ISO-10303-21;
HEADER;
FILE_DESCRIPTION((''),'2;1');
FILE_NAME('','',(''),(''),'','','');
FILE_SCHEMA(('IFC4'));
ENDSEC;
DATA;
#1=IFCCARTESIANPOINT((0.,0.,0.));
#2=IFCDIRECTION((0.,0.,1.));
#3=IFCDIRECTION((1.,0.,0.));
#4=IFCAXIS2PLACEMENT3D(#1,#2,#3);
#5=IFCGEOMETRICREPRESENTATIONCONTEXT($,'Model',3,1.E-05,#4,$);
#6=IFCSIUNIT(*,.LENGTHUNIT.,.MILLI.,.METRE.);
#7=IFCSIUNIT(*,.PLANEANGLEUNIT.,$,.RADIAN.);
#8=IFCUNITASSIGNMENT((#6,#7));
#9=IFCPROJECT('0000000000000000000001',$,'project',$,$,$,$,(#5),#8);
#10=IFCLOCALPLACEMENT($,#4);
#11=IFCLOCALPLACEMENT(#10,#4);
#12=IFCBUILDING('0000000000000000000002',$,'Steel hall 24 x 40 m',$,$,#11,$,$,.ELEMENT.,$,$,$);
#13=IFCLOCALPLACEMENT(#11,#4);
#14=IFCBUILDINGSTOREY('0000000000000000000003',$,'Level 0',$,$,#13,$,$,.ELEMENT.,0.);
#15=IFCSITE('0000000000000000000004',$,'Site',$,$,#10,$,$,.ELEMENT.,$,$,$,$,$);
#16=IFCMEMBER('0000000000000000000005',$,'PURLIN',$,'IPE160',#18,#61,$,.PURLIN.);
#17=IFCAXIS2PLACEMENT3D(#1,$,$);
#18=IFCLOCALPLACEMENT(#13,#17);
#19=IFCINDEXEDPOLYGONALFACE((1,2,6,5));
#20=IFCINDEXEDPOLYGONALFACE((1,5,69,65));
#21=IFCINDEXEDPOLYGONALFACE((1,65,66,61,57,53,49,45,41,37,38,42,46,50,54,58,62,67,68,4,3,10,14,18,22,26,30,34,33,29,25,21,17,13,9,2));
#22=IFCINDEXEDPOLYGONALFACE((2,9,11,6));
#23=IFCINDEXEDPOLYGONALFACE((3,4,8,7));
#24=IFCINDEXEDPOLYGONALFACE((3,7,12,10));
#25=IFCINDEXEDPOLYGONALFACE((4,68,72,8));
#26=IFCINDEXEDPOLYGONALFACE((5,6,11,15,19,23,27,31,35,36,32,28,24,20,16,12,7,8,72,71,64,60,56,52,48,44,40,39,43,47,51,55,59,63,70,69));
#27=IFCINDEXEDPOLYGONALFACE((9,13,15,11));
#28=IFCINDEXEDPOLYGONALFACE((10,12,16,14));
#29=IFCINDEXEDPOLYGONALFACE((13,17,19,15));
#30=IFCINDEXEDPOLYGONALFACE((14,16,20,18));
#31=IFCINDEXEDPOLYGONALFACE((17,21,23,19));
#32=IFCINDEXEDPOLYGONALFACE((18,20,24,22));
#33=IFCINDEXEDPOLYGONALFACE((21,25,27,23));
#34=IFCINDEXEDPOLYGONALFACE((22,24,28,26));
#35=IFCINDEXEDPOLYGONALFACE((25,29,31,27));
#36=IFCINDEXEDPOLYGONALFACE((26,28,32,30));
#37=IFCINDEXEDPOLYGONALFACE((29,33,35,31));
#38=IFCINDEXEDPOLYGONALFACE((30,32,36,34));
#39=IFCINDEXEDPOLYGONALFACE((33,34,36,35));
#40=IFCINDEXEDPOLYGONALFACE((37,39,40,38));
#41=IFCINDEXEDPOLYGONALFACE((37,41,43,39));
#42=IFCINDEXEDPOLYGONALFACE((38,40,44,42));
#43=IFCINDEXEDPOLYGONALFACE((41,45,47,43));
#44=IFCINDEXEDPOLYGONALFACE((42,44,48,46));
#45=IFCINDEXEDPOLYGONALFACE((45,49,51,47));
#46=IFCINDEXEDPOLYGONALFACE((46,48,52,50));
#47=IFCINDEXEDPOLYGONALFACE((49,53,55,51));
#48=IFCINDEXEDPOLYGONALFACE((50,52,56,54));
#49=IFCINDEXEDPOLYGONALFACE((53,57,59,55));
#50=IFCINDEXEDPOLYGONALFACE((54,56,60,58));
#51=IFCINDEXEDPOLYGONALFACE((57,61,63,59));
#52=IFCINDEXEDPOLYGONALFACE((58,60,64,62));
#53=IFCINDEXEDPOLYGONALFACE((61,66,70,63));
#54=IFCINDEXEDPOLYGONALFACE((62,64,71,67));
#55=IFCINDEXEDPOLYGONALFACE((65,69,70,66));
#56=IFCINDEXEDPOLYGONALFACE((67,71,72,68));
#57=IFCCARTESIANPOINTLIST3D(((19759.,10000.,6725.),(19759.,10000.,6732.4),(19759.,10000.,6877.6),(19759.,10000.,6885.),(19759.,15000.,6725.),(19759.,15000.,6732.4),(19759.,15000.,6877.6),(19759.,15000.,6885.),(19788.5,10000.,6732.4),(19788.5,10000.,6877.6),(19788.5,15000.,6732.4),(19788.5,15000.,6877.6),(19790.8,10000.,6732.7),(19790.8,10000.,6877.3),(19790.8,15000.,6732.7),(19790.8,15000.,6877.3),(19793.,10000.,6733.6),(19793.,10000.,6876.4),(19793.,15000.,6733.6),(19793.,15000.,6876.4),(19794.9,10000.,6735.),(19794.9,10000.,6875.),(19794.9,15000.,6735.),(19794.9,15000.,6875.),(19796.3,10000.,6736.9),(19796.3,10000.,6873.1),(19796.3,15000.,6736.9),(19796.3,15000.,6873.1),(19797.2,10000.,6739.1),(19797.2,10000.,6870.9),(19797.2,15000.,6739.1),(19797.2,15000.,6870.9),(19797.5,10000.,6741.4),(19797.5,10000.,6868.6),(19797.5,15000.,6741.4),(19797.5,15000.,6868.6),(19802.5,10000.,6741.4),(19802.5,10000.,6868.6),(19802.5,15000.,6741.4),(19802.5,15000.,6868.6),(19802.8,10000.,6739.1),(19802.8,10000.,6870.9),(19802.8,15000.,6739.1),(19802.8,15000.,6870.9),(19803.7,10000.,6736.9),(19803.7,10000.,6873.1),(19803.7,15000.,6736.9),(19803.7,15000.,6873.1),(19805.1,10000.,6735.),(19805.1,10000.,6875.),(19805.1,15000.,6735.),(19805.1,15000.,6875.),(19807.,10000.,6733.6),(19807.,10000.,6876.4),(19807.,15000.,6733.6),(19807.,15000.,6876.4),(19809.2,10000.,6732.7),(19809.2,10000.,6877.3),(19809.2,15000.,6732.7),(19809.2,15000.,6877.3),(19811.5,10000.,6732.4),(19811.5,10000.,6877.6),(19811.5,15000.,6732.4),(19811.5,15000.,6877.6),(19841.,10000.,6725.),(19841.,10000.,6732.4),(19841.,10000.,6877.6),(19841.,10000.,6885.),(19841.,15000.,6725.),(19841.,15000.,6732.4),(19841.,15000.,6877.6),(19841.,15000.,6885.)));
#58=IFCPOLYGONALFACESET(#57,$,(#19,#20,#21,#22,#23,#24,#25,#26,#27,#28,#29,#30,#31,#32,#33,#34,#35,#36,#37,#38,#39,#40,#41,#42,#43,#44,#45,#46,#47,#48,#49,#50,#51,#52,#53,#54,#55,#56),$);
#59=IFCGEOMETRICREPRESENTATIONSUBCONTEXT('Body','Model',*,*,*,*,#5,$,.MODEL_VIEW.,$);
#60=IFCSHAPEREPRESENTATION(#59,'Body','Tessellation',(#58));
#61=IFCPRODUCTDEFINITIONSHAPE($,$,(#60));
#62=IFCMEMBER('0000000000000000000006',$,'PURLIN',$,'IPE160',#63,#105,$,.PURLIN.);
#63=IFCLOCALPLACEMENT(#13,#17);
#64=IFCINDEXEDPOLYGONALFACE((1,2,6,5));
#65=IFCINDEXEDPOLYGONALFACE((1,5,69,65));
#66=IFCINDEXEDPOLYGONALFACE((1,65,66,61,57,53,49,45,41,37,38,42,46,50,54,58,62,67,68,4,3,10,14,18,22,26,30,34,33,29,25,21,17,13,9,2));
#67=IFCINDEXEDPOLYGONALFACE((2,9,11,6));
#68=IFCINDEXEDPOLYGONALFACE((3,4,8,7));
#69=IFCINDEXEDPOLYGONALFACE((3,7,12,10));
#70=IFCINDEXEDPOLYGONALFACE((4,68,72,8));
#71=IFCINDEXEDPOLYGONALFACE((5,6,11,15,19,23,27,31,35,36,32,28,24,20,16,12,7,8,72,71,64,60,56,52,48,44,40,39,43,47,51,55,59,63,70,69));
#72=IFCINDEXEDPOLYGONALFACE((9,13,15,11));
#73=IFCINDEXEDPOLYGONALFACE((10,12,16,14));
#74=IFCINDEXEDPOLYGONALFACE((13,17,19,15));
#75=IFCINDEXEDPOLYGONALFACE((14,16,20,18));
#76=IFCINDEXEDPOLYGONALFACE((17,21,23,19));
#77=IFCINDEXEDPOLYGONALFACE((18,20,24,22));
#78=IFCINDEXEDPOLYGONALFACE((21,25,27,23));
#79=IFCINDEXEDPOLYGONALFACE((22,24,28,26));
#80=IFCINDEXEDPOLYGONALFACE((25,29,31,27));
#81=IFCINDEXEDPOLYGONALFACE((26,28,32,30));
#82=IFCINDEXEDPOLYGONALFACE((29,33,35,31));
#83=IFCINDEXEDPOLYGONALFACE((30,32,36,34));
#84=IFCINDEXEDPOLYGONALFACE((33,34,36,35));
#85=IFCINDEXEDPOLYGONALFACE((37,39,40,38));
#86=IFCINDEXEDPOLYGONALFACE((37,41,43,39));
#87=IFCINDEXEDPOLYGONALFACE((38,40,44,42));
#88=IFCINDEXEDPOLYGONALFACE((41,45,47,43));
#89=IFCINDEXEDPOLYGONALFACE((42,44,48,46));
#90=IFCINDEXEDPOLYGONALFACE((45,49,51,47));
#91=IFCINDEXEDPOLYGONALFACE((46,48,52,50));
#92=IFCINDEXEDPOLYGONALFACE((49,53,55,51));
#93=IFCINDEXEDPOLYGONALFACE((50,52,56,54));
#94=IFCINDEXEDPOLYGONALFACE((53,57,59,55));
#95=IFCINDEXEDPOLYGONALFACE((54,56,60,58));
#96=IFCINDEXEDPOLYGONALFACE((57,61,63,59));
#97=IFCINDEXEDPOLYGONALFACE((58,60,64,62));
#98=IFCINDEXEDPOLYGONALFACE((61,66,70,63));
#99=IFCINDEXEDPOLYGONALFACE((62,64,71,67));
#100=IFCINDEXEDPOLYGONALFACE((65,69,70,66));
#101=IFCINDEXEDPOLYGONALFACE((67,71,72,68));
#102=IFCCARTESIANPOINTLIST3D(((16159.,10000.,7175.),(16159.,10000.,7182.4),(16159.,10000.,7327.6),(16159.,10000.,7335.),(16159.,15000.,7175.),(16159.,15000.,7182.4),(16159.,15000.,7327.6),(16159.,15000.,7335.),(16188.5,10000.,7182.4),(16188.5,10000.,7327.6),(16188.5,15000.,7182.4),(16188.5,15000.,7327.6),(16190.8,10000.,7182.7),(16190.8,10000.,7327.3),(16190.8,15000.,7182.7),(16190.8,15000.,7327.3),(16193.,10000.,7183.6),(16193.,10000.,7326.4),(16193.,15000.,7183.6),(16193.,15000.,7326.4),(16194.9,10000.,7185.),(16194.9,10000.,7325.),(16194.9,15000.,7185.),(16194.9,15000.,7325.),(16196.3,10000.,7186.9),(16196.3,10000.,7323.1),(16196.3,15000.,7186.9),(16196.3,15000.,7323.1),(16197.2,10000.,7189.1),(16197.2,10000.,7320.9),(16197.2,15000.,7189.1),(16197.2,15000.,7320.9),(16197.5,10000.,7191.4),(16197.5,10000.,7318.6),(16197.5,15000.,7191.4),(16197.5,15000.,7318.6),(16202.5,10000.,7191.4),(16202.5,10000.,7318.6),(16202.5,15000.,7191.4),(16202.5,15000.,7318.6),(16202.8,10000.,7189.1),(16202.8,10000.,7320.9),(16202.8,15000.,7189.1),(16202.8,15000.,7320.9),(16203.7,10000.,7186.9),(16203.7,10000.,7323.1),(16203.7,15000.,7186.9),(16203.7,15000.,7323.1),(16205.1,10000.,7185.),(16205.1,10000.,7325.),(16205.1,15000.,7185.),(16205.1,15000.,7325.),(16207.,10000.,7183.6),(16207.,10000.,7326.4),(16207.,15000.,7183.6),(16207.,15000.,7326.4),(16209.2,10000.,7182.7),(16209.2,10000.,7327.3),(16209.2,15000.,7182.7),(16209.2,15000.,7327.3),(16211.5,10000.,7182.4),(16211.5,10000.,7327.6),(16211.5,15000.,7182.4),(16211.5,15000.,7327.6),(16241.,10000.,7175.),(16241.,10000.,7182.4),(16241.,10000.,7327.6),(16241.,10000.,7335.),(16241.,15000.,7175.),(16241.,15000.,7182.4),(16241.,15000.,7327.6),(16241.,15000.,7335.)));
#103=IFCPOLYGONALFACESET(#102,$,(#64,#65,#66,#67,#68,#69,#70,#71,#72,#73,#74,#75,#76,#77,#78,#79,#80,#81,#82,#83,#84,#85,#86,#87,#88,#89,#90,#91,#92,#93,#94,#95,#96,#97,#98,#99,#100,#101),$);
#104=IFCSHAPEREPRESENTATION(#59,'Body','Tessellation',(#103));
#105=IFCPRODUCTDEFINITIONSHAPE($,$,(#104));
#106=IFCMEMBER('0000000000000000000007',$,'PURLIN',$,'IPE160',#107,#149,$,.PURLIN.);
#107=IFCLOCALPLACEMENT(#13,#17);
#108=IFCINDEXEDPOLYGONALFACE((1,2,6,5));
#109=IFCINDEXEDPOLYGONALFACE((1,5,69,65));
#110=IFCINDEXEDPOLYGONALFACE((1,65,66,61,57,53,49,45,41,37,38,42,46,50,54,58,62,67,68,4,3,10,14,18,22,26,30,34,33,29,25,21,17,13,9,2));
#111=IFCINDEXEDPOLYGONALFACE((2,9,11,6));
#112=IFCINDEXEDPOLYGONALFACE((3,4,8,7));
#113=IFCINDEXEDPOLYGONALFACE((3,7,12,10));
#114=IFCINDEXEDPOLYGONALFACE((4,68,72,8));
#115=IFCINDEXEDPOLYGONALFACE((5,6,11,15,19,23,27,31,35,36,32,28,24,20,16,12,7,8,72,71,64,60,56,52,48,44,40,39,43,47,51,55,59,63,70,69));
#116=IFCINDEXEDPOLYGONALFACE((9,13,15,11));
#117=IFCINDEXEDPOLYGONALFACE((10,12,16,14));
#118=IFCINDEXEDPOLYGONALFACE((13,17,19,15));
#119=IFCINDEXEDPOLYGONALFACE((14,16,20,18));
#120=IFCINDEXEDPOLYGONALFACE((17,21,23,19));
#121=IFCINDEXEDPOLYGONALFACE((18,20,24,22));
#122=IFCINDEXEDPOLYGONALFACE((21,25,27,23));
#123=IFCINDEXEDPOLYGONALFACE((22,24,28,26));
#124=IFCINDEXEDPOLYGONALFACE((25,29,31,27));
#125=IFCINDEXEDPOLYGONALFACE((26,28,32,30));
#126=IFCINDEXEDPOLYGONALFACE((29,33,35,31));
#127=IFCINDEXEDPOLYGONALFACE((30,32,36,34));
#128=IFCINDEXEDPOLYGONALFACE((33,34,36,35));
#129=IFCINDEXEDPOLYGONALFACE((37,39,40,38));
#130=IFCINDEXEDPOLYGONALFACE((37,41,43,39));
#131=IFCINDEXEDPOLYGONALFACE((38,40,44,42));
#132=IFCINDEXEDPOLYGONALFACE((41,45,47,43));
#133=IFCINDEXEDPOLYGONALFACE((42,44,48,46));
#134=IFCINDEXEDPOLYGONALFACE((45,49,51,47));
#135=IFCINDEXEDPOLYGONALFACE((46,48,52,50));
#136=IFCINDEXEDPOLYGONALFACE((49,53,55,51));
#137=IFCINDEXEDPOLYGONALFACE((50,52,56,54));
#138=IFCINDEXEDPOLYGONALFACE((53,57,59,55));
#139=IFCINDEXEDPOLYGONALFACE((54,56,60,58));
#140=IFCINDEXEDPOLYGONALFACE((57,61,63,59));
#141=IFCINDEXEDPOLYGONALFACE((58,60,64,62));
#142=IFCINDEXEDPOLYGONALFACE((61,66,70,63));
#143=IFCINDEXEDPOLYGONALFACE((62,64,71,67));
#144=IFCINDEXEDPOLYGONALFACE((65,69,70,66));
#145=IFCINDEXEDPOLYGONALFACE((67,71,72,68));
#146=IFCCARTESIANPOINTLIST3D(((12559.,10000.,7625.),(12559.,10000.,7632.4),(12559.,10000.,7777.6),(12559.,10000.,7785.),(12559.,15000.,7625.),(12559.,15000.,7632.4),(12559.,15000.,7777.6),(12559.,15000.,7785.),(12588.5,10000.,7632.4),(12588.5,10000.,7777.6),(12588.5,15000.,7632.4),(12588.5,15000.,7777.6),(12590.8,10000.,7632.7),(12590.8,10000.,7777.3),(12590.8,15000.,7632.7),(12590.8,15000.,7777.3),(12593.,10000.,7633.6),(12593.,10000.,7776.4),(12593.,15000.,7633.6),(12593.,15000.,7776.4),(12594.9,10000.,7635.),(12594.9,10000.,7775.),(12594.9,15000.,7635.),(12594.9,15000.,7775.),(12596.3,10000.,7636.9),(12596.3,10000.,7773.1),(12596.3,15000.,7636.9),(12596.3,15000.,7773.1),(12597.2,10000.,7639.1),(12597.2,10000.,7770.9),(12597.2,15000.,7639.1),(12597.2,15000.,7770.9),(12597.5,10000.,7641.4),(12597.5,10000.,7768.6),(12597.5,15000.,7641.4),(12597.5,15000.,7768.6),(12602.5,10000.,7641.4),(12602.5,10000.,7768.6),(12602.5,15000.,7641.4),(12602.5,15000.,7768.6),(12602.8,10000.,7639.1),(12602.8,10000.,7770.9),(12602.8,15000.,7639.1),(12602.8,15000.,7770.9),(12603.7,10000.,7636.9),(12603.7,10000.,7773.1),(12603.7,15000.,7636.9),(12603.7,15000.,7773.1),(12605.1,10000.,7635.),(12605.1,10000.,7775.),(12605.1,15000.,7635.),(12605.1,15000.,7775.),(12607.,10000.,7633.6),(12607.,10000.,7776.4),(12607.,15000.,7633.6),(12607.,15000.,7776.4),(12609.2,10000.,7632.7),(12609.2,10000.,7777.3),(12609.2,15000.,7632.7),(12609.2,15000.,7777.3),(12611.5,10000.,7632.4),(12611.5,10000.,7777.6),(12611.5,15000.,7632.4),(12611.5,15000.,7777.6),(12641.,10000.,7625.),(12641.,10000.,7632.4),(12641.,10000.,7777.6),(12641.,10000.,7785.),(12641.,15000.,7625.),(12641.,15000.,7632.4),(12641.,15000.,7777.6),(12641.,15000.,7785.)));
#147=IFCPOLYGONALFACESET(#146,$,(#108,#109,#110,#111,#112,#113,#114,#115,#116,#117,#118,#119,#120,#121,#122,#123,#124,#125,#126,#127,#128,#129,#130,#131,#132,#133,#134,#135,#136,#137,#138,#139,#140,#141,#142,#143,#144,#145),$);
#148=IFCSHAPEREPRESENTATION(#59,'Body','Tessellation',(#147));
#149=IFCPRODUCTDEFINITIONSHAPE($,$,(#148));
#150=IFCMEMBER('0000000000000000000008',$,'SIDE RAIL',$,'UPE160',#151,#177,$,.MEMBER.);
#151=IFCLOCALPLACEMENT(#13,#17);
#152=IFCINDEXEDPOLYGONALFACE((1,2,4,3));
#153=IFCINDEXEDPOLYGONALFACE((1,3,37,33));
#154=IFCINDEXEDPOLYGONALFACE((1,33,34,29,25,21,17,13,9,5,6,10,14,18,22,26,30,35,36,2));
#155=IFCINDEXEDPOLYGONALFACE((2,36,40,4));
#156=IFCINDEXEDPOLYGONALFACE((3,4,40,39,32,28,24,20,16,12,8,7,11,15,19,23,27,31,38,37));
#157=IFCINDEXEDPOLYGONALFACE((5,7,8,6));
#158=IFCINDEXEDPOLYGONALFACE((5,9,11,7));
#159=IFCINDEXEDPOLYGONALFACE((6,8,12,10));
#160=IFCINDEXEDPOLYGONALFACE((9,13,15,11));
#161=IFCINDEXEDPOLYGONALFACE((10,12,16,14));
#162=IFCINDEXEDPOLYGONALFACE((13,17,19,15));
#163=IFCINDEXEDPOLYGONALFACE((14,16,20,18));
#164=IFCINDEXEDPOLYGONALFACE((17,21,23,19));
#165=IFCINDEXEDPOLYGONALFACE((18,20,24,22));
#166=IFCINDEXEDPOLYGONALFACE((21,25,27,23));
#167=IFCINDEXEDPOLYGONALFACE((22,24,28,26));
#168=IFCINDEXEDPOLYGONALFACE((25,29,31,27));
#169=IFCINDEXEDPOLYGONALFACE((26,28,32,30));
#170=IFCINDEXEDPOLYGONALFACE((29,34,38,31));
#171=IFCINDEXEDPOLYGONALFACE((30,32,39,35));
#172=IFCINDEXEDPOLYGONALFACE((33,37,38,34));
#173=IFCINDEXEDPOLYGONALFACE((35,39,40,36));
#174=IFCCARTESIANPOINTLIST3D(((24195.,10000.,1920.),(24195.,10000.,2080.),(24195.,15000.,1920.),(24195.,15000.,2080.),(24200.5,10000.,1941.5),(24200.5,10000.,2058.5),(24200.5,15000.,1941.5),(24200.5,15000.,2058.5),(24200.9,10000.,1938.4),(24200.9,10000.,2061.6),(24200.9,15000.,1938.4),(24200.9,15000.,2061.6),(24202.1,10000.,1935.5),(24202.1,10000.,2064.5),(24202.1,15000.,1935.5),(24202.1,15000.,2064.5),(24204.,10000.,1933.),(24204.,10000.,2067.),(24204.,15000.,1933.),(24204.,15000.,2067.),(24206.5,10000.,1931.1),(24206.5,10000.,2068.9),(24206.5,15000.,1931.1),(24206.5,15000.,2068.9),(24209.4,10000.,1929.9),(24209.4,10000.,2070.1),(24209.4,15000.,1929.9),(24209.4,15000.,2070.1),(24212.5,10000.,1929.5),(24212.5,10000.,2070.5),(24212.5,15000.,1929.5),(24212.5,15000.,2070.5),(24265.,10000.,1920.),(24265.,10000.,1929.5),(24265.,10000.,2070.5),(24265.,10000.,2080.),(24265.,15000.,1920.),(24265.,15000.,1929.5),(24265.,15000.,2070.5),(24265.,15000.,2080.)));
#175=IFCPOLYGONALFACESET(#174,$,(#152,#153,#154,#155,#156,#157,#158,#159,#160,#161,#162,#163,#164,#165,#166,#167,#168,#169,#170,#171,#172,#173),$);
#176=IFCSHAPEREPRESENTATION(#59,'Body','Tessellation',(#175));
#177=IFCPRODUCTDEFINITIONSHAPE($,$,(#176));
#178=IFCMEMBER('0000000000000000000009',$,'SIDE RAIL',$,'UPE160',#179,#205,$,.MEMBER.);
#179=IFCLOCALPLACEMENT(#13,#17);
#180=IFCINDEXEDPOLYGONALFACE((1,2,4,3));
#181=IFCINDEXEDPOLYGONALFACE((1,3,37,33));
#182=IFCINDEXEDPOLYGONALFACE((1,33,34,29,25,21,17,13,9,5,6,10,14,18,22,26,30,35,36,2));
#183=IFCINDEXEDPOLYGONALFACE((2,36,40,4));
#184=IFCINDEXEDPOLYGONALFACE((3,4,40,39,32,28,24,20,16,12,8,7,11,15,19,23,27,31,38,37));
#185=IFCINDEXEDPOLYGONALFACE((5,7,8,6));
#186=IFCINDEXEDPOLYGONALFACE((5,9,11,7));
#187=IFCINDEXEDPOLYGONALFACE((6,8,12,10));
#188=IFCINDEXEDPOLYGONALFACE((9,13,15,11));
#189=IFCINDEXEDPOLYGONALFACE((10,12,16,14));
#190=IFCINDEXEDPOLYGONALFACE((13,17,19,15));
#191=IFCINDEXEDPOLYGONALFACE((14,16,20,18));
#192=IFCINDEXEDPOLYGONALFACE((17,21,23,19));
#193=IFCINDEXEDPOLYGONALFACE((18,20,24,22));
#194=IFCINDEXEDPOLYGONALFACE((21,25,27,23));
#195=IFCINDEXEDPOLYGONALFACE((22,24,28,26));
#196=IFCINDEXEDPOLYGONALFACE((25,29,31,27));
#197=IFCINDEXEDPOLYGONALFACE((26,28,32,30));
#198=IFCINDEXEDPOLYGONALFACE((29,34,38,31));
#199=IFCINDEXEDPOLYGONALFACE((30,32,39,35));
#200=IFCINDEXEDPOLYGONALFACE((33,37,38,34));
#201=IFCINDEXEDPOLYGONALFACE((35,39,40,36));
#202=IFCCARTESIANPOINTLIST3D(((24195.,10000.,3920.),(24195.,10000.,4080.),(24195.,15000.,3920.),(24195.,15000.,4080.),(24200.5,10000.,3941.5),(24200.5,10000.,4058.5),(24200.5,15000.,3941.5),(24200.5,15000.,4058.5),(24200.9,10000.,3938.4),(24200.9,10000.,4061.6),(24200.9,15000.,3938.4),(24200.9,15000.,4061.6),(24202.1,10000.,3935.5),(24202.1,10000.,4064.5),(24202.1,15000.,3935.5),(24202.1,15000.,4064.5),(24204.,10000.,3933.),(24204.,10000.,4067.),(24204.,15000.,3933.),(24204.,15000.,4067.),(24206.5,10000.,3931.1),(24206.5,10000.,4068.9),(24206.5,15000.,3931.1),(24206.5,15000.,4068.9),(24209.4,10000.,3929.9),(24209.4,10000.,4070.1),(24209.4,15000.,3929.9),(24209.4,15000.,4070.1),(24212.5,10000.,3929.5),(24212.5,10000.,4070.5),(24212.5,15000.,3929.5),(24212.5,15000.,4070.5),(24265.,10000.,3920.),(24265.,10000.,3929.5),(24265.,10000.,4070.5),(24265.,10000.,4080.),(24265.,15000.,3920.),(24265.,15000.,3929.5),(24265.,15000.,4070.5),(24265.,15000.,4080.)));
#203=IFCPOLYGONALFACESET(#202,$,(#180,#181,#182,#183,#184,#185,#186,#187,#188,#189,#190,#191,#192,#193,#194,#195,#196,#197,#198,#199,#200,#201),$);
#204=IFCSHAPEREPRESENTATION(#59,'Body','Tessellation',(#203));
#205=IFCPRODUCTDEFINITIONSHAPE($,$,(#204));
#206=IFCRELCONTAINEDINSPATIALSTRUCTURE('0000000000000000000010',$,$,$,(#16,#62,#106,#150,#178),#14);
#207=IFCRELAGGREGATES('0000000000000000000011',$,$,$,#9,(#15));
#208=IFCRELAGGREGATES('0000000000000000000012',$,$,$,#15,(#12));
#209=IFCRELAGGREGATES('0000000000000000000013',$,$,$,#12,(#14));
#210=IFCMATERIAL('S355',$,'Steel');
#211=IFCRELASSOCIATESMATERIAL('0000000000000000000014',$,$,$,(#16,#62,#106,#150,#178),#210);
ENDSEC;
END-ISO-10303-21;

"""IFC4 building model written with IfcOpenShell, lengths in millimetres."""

from ifc_helpers import new_model, si_unit, frame, origin_with_axes, place, context, subcontext, project, spatial, i_section, u_section, extrude, material, element, save


model = new_model("IFC4")

# Units and contexts
model_context = context("Model", 3, precision=1e-05, world=origin_with_axes())
body_context = subcontext(model_context, "Body", "Model", "MODEL_VIEW")
ifc_project = project(units=[si_unit("LENGTHUNIT", "METRE", prefix="MILLI"), si_unit("PLANEANGLEUNIT", "RADIAN")], contexts=[model_context])

# Site, building, storey
site_placement = place(None, origin_with_axes())
site = spatial("IfcSite", under=ifc_project, at=site_placement, Name="Site", CompositionType="ELEMENT")
building_placement = place(site_placement, origin_with_axes())
building = spatial("IfcBuilding", under=site, at=building_placement, Name="Steel hall 24 x 40 m", CompositionType="ELEMENT")
storey_placement = place(building_placement, origin_with_axes())
storey = spatial("IfcBuildingStorey", under=building, at=storey_placement, Name="Level 0", CompositionType="ELEMENT", Elevation=0.0)

# Shared definitions
ifc_material = material(Name="S355", Category="Steel")

# Members
for number, where, z_axis, x_axis, name in (
    (1, (19800.0, 10000.0, 6805.0), (0.0, 1.0, 0.0), (1.0, 0.0, 0.0), "PURLIN"),
    (2, (16200.0, 10000.0, 7255.0), (0.0, 1.0, 0.0), (1.0, 0.0, 0.0), "PURLIN"),
    (3, (12600.0, 10000.0, 7705.0), (0.0, 1.0, 0.0), (1.0, 0.0, 0.0), "PURLIN"),
):
    element("IfcMember", number, at=place(storey_placement, frame(where, z_axis=z_axis, x_axis=x_axis)), inside=storey, material=ifc_material, Name=name, ObjectType="IPE160", PredefinedType="PURLIN", context=body_context, shape_type="SweptSolid", body=[
        extrude(i_section(OverallWidth=82.0, OverallDepth=160.0, WebThickness=5.0, FlangeThickness=7.4, FilletRadius=9.0), origin_with_axes(), (0.0, 0.0, 1.0), 5000.0),
    ])
for number, where, z_axis, x_axis, name in (
    (4, (24230.0, 10000.0, 2000.0), (0.0, 1.0, 0.0), (1.0, 0.0, 0.0), "SIDE RAIL"),
    (5, (24230.0, 10000.0, 4000.0), (0.0, 1.0, 0.0), (1.0, 0.0, 0.0), "SIDE RAIL"),
):
    element("IfcMember", number, at=place(storey_placement, frame(where, z_axis=z_axis, x_axis=x_axis)), inside=storey, material=ifc_material, Name=name, ObjectType="UPE160", PredefinedType="MEMBER", context=body_context, shape_type="SweptSolid", body=[
        extrude(u_section(Depth=160.0, FlangeWidth=70.0, WebThickness=5.5, FlangeThickness=9.5, FilletRadius=12.0), origin_with_axes(), (0.0, 0.0, 1.0), 5000.0),
    ])

save(model, "model.ifc")
